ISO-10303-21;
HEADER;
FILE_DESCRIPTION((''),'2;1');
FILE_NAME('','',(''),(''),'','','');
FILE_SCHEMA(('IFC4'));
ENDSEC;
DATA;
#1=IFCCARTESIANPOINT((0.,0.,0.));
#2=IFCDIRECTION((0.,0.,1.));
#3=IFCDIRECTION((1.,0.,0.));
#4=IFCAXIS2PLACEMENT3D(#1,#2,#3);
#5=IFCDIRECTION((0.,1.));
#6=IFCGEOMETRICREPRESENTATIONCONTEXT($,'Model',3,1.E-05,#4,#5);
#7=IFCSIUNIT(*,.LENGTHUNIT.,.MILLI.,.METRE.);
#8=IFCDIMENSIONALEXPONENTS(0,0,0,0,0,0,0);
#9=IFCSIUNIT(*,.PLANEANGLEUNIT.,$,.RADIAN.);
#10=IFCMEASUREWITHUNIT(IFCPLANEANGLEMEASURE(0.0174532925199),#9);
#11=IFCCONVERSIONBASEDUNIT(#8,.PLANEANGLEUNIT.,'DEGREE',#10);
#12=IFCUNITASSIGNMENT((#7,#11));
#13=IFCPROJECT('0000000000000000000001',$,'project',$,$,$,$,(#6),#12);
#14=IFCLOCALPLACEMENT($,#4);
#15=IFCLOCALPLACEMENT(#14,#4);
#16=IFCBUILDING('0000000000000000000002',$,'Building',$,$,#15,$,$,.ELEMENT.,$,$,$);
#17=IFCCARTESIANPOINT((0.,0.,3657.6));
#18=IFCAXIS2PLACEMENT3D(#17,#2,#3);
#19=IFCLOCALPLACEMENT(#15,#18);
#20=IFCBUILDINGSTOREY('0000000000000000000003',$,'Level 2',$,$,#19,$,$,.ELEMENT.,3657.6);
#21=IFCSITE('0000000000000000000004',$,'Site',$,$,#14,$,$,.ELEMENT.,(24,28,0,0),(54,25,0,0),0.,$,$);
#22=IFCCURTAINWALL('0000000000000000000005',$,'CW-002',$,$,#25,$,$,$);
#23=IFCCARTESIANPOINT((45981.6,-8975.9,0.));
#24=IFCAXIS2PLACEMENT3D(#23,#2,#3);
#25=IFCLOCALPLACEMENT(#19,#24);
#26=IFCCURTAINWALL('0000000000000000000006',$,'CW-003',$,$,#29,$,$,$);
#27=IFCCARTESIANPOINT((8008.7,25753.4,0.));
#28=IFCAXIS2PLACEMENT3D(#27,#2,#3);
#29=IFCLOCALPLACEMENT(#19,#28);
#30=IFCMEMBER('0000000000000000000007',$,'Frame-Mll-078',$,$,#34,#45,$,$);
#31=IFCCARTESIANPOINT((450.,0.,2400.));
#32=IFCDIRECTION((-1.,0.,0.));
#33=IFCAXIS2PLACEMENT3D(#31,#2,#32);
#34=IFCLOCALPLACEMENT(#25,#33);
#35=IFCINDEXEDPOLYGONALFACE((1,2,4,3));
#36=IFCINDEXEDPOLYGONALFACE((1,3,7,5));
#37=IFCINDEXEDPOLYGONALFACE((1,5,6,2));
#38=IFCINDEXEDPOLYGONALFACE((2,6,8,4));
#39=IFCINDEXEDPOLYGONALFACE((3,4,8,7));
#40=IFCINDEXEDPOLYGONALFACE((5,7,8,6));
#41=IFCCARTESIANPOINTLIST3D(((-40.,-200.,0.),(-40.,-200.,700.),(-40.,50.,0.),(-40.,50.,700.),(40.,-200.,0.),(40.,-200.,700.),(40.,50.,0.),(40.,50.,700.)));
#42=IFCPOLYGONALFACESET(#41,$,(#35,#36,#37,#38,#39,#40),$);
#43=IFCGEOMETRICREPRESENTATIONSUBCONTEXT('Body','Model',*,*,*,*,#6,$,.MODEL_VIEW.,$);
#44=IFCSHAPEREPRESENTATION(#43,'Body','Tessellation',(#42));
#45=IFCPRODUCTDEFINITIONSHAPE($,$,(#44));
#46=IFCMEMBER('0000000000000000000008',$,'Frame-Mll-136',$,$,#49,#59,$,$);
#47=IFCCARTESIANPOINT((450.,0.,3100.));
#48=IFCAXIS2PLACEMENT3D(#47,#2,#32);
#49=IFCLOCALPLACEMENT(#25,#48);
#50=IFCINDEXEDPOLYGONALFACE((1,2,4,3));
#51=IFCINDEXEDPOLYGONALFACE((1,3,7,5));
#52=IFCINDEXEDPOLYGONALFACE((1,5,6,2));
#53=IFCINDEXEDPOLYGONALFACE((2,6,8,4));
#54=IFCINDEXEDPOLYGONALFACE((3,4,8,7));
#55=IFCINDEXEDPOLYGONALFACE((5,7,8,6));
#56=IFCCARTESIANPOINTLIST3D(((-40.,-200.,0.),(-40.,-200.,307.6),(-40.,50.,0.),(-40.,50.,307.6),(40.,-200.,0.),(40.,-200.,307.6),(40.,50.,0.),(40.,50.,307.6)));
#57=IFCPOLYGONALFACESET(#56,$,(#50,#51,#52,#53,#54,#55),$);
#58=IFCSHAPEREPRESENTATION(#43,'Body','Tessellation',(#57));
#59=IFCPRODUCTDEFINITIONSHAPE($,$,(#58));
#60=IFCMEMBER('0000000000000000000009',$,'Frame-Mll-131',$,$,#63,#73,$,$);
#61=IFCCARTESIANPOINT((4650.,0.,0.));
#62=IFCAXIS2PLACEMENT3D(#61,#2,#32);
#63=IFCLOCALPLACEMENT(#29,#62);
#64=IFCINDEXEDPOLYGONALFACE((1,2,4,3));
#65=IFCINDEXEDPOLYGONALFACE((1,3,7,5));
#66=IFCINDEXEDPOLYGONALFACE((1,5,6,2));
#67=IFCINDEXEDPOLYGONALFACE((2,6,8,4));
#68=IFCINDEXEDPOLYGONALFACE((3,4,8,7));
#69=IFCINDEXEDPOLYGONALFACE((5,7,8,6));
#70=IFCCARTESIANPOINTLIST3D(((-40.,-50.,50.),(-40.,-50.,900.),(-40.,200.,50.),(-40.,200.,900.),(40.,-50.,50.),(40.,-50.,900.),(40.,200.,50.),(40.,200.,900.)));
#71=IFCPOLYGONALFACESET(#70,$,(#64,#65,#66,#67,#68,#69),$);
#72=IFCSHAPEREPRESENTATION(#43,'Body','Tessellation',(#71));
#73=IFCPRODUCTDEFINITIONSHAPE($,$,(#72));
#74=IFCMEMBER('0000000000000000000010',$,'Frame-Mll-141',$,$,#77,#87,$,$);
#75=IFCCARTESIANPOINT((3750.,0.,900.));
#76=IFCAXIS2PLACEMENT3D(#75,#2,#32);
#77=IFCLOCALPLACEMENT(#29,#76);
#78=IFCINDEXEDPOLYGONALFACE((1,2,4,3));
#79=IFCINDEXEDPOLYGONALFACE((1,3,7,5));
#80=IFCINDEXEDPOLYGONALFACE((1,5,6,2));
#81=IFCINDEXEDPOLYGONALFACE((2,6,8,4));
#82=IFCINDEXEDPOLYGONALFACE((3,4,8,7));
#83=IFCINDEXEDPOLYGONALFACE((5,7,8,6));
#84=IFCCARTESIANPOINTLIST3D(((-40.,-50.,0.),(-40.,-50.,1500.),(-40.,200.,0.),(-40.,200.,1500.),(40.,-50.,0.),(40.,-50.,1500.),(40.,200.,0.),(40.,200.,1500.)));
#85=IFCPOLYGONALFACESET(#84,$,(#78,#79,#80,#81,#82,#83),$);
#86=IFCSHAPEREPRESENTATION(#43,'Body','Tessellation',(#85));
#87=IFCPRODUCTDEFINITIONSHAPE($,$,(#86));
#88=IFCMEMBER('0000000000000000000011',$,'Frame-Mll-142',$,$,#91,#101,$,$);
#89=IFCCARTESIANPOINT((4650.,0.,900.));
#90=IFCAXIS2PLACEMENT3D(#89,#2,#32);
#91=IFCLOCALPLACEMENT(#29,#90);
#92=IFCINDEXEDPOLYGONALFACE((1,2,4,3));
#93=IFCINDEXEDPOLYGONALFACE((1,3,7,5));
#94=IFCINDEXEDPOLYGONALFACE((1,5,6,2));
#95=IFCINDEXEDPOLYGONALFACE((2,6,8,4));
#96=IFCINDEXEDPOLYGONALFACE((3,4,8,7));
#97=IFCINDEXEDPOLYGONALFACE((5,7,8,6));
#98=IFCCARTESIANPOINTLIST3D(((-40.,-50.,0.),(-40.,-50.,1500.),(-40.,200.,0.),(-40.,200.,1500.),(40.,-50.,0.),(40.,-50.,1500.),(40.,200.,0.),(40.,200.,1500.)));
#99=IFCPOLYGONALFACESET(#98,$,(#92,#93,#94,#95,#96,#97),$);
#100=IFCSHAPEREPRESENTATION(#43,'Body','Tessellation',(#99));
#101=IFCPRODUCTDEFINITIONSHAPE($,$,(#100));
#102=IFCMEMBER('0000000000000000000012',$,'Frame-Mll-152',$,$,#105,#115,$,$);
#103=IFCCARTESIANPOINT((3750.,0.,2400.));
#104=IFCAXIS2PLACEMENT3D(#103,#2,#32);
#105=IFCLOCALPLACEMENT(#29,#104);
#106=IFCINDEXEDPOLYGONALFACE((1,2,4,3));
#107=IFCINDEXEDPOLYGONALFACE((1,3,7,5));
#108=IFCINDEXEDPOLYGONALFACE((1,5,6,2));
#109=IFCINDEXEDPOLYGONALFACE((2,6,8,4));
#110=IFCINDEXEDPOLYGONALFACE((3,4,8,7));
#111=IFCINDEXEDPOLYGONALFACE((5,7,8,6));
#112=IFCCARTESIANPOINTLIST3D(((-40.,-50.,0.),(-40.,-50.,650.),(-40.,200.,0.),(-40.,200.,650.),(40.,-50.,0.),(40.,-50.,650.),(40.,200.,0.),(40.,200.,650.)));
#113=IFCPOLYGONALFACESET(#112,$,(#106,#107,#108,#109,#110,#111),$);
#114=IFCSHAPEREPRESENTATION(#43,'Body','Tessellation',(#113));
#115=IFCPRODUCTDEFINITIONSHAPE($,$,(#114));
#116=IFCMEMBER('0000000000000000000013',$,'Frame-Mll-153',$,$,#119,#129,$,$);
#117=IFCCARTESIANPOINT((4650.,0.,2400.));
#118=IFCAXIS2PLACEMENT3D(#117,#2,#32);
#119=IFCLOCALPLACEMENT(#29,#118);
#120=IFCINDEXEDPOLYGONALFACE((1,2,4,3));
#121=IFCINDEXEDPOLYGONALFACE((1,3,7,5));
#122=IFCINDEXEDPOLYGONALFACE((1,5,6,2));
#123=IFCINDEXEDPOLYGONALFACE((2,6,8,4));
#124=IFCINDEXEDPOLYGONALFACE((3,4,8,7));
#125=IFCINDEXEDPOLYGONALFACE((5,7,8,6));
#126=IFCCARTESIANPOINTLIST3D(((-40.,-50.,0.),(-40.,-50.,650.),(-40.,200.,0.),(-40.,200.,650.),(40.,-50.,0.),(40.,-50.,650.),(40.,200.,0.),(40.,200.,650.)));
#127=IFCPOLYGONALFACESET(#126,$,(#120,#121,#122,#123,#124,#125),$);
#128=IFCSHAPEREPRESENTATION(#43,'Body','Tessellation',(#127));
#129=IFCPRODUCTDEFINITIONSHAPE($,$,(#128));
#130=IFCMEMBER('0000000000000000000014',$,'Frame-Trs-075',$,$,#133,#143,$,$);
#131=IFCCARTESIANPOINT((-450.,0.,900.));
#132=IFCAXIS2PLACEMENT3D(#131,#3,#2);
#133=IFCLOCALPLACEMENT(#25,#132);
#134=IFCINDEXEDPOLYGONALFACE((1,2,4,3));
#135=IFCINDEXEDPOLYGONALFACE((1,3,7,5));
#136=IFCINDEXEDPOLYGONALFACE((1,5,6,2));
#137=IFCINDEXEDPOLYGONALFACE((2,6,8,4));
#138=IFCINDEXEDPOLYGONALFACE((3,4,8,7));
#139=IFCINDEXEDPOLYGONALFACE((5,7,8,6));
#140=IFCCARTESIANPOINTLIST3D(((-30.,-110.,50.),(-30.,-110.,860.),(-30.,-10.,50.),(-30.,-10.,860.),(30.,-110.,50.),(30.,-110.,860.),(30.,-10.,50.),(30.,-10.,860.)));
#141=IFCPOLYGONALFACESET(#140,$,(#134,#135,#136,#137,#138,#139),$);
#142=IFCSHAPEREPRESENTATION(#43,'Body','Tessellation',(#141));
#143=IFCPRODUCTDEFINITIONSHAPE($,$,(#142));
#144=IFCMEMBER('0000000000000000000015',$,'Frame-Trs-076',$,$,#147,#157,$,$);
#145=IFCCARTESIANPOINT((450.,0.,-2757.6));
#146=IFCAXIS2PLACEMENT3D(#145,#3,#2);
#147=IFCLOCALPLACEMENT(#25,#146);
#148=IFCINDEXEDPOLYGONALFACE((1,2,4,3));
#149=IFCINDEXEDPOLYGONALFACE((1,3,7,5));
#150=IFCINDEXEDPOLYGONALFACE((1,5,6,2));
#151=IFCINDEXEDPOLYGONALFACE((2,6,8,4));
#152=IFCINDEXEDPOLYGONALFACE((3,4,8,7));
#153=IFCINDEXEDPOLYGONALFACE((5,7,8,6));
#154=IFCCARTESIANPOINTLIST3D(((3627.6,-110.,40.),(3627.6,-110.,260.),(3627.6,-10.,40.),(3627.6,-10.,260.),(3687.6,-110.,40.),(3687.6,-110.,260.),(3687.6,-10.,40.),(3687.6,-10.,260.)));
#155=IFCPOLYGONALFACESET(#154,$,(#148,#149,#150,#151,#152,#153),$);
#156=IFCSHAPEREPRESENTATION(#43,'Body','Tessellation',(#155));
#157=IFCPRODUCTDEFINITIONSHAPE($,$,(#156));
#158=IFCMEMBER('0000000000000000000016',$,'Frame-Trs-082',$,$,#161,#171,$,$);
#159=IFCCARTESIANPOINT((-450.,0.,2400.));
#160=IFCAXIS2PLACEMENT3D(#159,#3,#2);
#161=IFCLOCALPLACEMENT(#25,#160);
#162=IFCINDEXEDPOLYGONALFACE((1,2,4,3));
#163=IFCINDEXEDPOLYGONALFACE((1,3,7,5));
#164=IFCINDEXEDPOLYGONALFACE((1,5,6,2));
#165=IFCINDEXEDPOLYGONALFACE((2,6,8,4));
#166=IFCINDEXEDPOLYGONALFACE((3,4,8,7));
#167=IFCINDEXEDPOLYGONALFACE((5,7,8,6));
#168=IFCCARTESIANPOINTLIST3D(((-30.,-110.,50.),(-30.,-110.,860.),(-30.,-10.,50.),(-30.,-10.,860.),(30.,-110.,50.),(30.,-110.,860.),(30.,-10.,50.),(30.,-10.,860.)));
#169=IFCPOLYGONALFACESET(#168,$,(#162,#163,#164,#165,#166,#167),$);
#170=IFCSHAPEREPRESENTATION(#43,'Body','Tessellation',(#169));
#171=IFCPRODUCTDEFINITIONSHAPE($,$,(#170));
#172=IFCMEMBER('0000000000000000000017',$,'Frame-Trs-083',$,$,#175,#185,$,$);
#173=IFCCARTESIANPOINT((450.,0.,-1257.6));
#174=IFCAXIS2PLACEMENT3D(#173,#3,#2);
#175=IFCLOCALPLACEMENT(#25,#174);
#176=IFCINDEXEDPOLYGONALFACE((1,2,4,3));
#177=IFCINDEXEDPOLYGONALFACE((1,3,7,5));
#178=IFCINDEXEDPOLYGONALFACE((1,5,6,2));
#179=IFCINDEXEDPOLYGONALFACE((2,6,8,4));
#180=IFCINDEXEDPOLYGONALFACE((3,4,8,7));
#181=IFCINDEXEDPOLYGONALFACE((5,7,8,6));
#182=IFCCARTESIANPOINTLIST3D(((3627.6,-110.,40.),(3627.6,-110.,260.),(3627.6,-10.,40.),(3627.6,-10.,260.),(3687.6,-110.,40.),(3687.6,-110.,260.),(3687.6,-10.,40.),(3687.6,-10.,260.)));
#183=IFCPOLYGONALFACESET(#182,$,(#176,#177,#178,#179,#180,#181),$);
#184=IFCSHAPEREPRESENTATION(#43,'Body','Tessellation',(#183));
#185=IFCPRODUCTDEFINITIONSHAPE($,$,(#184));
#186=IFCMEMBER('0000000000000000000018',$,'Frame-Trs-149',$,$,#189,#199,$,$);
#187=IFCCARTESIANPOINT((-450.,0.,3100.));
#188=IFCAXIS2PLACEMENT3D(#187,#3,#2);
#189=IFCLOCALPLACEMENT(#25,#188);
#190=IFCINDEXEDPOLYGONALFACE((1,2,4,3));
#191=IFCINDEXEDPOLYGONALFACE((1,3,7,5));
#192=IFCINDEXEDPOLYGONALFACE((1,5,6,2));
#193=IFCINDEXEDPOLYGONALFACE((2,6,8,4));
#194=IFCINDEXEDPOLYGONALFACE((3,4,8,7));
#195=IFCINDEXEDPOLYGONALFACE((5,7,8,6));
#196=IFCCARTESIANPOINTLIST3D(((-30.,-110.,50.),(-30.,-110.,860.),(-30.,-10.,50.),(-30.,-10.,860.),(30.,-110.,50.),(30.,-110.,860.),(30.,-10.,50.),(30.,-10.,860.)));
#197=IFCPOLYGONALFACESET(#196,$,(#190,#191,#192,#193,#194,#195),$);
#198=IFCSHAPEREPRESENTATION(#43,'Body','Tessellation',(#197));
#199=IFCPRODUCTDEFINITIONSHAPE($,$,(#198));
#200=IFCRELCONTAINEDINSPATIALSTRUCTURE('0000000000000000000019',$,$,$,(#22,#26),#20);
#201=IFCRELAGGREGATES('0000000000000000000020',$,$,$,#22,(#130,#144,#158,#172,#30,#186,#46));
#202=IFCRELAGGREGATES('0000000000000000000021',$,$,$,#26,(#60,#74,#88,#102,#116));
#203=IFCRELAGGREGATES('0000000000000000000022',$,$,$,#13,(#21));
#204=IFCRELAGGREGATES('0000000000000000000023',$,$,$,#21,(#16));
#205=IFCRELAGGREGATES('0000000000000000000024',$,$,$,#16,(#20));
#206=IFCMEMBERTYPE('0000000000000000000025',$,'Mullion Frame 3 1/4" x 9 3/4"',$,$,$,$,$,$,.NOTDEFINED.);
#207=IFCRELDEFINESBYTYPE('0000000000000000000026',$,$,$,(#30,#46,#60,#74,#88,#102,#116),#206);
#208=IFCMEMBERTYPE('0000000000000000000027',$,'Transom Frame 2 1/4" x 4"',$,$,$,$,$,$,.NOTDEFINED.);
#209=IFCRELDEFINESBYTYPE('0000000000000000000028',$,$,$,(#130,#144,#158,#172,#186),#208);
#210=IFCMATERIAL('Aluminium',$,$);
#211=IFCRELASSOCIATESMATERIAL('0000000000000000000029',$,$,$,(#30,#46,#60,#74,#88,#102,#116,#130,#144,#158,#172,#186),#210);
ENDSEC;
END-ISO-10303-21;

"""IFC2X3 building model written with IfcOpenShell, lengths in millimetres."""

from ifc_helpers import new_model, entity, si_unit, converted_unit, direction, frame, origin_with_axes, place, context, subcontext, project, spatial, polyline, outline, extrude, material, type_object, element, aggregate, save


model = new_model("IFC2X3")

# Units and contexts
model_context = context("Model", 3, precision=1e-05, world=origin_with_axes(), true_north=direction((0.0, 1.0)))
body_context = subcontext(model_context, "Body", "Model", "MODEL_VIEW")
ifc_project = project(units=[si_unit("LENGTHUNIT", "METRE", prefix="MILLI"), converted_unit("PLANEANGLEUNIT", "DEGREE", entity("IfcPlaneAngleMeasure", 0.0174532925199), si_unit("PLANEANGLEUNIT", "RADIAN"), dimensions=[0, 0, 0, 0, 0, 0, 0])], contexts=[model_context])

# Site, building, storey
site_placement = place(None, origin_with_axes())
site = spatial("IfcSite", under=ifc_project, at=site_placement, Name="Site", CompositionType="ELEMENT", RefLatitude=(24, 28, 0, 0), RefLongitude=(54, 25, 0, 0), RefElevation=0.0)
building_placement = place(site_placement, origin_with_axes())
building = spatial("IfcBuilding", under=site, at=building_placement, Name="Building", CompositionType="ELEMENT")
storey_placement = place(building_placement, frame((0.0, 0.0, 3657.6), z_axis=(0.0, 0.0, 1.0), x_axis=(1.0, 0.0, 0.0)))
storey = spatial("IfcBuildingStorey", under=building, at=storey_placement, Name="Level 2", CompositionType="ELEMENT", Elevation=3657.6)

# Curtain walls
curtain_wall_1_placement = place(storey_placement, frame((45981.6, -8975.9, 0.0), z_axis=(0.0, 0.0, 1.0), x_axis=(1.0, 0.0, 0.0)))
curtain_wall_1 = element("IfcCurtainWall", 1, at=curtain_wall_1_placement, inside=storey, Name="CW-002")
ifc_material_1 = material(Name="Aluminium")
curtain_wall_2_placement = place(storey_placement, frame((8008.7, 25753.4, 0.0), z_axis=(0.0, 0.0, 1.0), x_axis=(1.0, 0.0, 0.0)))
curtain_wall_2 = element("IfcCurtainWall", 2, at=curtain_wall_2_placement, inside=storey, Name="CW-003")

# Members
member_type_1 = type_object("IfcMemberType", Name="Mullion Frame 3 1/4\" x 9 3/4\"", PredefinedType="NOTDEFINED")
member_1_placement = place(curtain_wall_1_placement, frame((450.0, 0.0, 2400.0), z_axis=(0.0, 0.0, 1.0), x_axis=(-1.0, 0.0, 0.0)))
member_1 = element("IfcMember", 3, at=member_1_placement, type_object=member_type_1, material=ifc_material_1, Name="Frame-Mll-078", context=body_context, shape_type="SweptSolid", body=[
    extrude(outline(polyline([(-40.0, 200.0), (-40.0, -50.0), (40.0, -50.0), (40.0, 200.0), (-40.0, 200.0)])), frame((0.0, 0.0, 0.0), z_axis=(0.0, 0.0, 1.0), x_axis=(-1.0, 0.0, 0.0)), (0.0, 0.0, 1.0), 700.0),
])
member_2_placement = place(curtain_wall_1_placement, frame((450.0, 0.0, 3100.0), z_axis=(0.0, 0.0, 1.0), x_axis=(-1.0, 0.0, 0.0)))
member_2 = element("IfcMember", 4, at=member_2_placement, type_object=member_type_1, material=ifc_material_1, Name="Frame-Mll-136", context=body_context, shape_type="SweptSolid", body=[
    extrude(outline(polyline([(-40.0, 200.0), (-40.0, -50.0), (40.0, -50.0), (40.0, 200.0), (-40.0, 200.0)])), frame((0.0, 0.0, 0.0), z_axis=(0.0, 0.0, 1.0), x_axis=(-1.0, 0.0, 0.0)), (0.0, 0.0, 1.0), 307.6),
])
member_3_placement = place(curtain_wall_2_placement, frame((4650.0, 0.0, 0.0), z_axis=(0.0, 0.0, 1.0), x_axis=(-1.0, 0.0, 0.0)))
member_3 = element("IfcMember", 5, at=member_3_placement, type_object=member_type_1, material=ifc_material_1, Name="Frame-Mll-131", context=body_context, shape_type="SweptSolid", body=[
    extrude(outline(polyline([(-40.0, -200.0), (40.0, -200.0), (40.0, 50.0), (-40.0, 50.0), (-40.0, -200.0)])), frame((0.0, 0.0, 50.0), z_axis=(0.0, 0.0, 1.0), x_axis=(-1.0, 0.0, 0.0)), (0.0, 0.0, 1.0), 850.0),
])
member_4_placement = place(curtain_wall_2_placement, frame((3750.0, 0.0, 900.0), z_axis=(0.0, 0.0, 1.0), x_axis=(-1.0, 0.0, 0.0)))
member_4 = element("IfcMember", 6, at=member_4_placement, type_object=member_type_1, material=ifc_material_1, Name="Frame-Mll-141", context=body_context, shape_type="SweptSolid", body=[
    extrude(outline(polyline([(-40.0, -200.0), (40.0, -200.0), (40.0, 50.0), (-40.0, 50.0), (-40.0, -200.0)])), frame((0.0, 0.0, 0.0), z_axis=(0.0, 0.0, 1.0), x_axis=(-1.0, 0.0, 0.0)), (0.0, 0.0, 1.0), 1500.0),
])
member_5_placement = place(curtain_wall_2_placement, frame((4650.0, 0.0, 900.0), z_axis=(0.0, 0.0, 1.0), x_axis=(-1.0, 0.0, 0.0)))
member_5 = element("IfcMember", 7, at=member_5_placement, type_object=member_type_1, material=ifc_material_1, Name="Frame-Mll-142", context=body_context, shape_type="SweptSolid", body=[
    extrude(outline(polyline([(-40.0, -200.0), (40.0, -200.0), (40.0, 50.0), (-40.0, 50.0), (-40.0, -200.0)])), frame((0.0, 0.0, 0.0), z_axis=(0.0, 0.0, 1.0), x_axis=(-1.0, 0.0, 0.0)), (0.0, 0.0, 1.0), 1500.0),
])
member_6_placement = place(curtain_wall_2_placement, frame((3750.0, 0.0, 2400.0), z_axis=(0.0, 0.0, 1.0), x_axis=(-1.0, 0.0, 0.0)))
member_6 = element("IfcMember", 8, at=member_6_placement, type_object=member_type_1, material=ifc_material_1, Name="Frame-Mll-152", context=body_context, shape_type="SweptSolid", body=[
    extrude(outline(polyline([(-40.0, -200.0), (40.0, -200.0), (40.0, 50.0), (-40.0, 50.0), (-40.0, -200.0)])), frame((0.0, 0.0, 0.0), z_axis=(0.0, 0.0, 1.0), x_axis=(-1.0, 0.0, 0.0)), (0.0, 0.0, 1.0), 650.0),
])
member_7_placement = place(curtain_wall_2_placement, frame((4650.0, 0.0, 2400.0), z_axis=(0.0, 0.0, 1.0), x_axis=(-1.0, 0.0, 0.0)))
member_7 = element("IfcMember", 9, at=member_7_placement, type_object=member_type_1, material=ifc_material_1, Name="Frame-Mll-153", context=body_context, shape_type="SweptSolid", body=[
    extrude(outline(polyline([(-40.0, -200.0), (40.0, -200.0), (40.0, 50.0), (-40.0, 50.0), (-40.0, -200.0)])), frame((0.0, 0.0, 0.0), z_axis=(0.0, 0.0, 1.0), x_axis=(-1.0, 0.0, 0.0)), (0.0, 0.0, 1.0), 650.0),
])
member_type_2 = type_object("IfcMemberType", Name="Transom Frame 2 1/4\" x 4\"", PredefinedType="NOTDEFINED")
member_8_placement = place(curtain_wall_1_placement, frame((-450.0, 0.0, 900.0), z_axis=(1.0, 0.0, 0.0), x_axis=(0.0, 0.0, 1.0)))
member_8 = element("IfcMember", 10, at=member_8_placement, type_object=member_type_2, material=ifc_material_1, Name="Frame-Trs-075", context=body_context, shape_type="SweptSolid", body=[
    extrude(outline(polyline([(-110.0, -30.0), (-10.0, -30.0), (-10.0, 30.0), (-110.0, 30.0), (-110.0, -30.0)])), frame((0.0, 0.0, 50.0), z_axis=(0.0, 0.0, 1.0), x_axis=(0.0, 1.0, 0.0)), (0.0, 0.0, 1.0), 810.0),
])
member_9_placement = place(curtain_wall_1_placement, frame((450.0, 0.0, -2757.6), z_axis=(1.0, 0.0, 0.0), x_axis=(0.0, 0.0, 1.0)))
member_9 = element("IfcMember", 11, at=member_9_placement, type_object=member_type_2, material=ifc_material_1, Name="Frame-Trs-076", context=body_context, shape_type="SweptSolid", body=[
    extrude(outline(polyline([(-110.0, -3687.6), (-10.0, -3687.6), (-10.0, -3627.6), (-110.0, -3627.6), (-110.0, -3687.6)])), frame((0.0, 0.0, 40.0), z_axis=(0.0, 0.0, 1.0), x_axis=(0.0, 1.0, 0.0)), (0.0, 0.0, 1.0), 220.0),
])
member_10_placement = place(curtain_wall_1_placement, frame((-450.0, 0.0, 2400.0), z_axis=(1.0, 0.0, 0.0), x_axis=(0.0, 0.0, 1.0)))
member_10 = element("IfcMember", 12, at=member_10_placement, type_object=member_type_2, material=ifc_material_1, Name="Frame-Trs-082", context=body_context, shape_type="SweptSolid", body=[
    extrude(outline(polyline([(-110.0, -30.0), (-10.0, -30.0), (-10.0, 30.0), (-110.0, 30.0), (-110.0, -30.0)])), frame((0.0, 0.0, 50.0), z_axis=(0.0, 0.0, 1.0), x_axis=(0.0, 1.0, 0.0)), (0.0, 0.0, 1.0), 810.0),
])
member_11_placement = place(curtain_wall_1_placement, frame((450.0, 0.0, -1257.6), z_axis=(1.0, 0.0, 0.0), x_axis=(0.0, 0.0, 1.0)))
member_11 = element("IfcMember", 13, at=member_11_placement, type_object=member_type_2, material=ifc_material_1, Name="Frame-Trs-083", context=body_context, shape_type="SweptSolid", body=[
    extrude(outline(polyline([(-110.0, -3687.6), (-10.0, -3687.6), (-10.0, -3627.6), (-110.0, -3627.6), (-110.0, -3687.6)])), frame((0.0, 0.0, 40.0), z_axis=(0.0, 0.0, 1.0), x_axis=(0.0, 1.0, 0.0)), (0.0, 0.0, 1.0), 220.0),
])
member_12_placement = place(curtain_wall_1_placement, frame((-450.0, 0.0, 3100.0), z_axis=(1.0, 0.0, 0.0), x_axis=(0.0, 0.0, 1.0)))
member_12 = element("IfcMember", 14, at=member_12_placement, type_object=member_type_2, material=ifc_material_1, Name="Frame-Trs-149", context=body_context, shape_type="SweptSolid", body=[
    extrude(outline(polyline([(-110.0, -30.0), (-10.0, -30.0), (-10.0, 30.0), (-110.0, 30.0), (-110.0, -30.0)])), frame((0.0, 0.0, 50.0), z_axis=(0.0, 0.0, 1.0), x_axis=(0.0, 1.0, 0.0)), (0.0, 0.0, 1.0), 810.0),
])

aggregate(curtain_wall_1, [member_8, member_9, member_10, member_11, member_1, member_12, member_2])
aggregate(curtain_wall_2, [member_3, member_4, member_5, member_6, member_7])

save(model, "model.ifc")
